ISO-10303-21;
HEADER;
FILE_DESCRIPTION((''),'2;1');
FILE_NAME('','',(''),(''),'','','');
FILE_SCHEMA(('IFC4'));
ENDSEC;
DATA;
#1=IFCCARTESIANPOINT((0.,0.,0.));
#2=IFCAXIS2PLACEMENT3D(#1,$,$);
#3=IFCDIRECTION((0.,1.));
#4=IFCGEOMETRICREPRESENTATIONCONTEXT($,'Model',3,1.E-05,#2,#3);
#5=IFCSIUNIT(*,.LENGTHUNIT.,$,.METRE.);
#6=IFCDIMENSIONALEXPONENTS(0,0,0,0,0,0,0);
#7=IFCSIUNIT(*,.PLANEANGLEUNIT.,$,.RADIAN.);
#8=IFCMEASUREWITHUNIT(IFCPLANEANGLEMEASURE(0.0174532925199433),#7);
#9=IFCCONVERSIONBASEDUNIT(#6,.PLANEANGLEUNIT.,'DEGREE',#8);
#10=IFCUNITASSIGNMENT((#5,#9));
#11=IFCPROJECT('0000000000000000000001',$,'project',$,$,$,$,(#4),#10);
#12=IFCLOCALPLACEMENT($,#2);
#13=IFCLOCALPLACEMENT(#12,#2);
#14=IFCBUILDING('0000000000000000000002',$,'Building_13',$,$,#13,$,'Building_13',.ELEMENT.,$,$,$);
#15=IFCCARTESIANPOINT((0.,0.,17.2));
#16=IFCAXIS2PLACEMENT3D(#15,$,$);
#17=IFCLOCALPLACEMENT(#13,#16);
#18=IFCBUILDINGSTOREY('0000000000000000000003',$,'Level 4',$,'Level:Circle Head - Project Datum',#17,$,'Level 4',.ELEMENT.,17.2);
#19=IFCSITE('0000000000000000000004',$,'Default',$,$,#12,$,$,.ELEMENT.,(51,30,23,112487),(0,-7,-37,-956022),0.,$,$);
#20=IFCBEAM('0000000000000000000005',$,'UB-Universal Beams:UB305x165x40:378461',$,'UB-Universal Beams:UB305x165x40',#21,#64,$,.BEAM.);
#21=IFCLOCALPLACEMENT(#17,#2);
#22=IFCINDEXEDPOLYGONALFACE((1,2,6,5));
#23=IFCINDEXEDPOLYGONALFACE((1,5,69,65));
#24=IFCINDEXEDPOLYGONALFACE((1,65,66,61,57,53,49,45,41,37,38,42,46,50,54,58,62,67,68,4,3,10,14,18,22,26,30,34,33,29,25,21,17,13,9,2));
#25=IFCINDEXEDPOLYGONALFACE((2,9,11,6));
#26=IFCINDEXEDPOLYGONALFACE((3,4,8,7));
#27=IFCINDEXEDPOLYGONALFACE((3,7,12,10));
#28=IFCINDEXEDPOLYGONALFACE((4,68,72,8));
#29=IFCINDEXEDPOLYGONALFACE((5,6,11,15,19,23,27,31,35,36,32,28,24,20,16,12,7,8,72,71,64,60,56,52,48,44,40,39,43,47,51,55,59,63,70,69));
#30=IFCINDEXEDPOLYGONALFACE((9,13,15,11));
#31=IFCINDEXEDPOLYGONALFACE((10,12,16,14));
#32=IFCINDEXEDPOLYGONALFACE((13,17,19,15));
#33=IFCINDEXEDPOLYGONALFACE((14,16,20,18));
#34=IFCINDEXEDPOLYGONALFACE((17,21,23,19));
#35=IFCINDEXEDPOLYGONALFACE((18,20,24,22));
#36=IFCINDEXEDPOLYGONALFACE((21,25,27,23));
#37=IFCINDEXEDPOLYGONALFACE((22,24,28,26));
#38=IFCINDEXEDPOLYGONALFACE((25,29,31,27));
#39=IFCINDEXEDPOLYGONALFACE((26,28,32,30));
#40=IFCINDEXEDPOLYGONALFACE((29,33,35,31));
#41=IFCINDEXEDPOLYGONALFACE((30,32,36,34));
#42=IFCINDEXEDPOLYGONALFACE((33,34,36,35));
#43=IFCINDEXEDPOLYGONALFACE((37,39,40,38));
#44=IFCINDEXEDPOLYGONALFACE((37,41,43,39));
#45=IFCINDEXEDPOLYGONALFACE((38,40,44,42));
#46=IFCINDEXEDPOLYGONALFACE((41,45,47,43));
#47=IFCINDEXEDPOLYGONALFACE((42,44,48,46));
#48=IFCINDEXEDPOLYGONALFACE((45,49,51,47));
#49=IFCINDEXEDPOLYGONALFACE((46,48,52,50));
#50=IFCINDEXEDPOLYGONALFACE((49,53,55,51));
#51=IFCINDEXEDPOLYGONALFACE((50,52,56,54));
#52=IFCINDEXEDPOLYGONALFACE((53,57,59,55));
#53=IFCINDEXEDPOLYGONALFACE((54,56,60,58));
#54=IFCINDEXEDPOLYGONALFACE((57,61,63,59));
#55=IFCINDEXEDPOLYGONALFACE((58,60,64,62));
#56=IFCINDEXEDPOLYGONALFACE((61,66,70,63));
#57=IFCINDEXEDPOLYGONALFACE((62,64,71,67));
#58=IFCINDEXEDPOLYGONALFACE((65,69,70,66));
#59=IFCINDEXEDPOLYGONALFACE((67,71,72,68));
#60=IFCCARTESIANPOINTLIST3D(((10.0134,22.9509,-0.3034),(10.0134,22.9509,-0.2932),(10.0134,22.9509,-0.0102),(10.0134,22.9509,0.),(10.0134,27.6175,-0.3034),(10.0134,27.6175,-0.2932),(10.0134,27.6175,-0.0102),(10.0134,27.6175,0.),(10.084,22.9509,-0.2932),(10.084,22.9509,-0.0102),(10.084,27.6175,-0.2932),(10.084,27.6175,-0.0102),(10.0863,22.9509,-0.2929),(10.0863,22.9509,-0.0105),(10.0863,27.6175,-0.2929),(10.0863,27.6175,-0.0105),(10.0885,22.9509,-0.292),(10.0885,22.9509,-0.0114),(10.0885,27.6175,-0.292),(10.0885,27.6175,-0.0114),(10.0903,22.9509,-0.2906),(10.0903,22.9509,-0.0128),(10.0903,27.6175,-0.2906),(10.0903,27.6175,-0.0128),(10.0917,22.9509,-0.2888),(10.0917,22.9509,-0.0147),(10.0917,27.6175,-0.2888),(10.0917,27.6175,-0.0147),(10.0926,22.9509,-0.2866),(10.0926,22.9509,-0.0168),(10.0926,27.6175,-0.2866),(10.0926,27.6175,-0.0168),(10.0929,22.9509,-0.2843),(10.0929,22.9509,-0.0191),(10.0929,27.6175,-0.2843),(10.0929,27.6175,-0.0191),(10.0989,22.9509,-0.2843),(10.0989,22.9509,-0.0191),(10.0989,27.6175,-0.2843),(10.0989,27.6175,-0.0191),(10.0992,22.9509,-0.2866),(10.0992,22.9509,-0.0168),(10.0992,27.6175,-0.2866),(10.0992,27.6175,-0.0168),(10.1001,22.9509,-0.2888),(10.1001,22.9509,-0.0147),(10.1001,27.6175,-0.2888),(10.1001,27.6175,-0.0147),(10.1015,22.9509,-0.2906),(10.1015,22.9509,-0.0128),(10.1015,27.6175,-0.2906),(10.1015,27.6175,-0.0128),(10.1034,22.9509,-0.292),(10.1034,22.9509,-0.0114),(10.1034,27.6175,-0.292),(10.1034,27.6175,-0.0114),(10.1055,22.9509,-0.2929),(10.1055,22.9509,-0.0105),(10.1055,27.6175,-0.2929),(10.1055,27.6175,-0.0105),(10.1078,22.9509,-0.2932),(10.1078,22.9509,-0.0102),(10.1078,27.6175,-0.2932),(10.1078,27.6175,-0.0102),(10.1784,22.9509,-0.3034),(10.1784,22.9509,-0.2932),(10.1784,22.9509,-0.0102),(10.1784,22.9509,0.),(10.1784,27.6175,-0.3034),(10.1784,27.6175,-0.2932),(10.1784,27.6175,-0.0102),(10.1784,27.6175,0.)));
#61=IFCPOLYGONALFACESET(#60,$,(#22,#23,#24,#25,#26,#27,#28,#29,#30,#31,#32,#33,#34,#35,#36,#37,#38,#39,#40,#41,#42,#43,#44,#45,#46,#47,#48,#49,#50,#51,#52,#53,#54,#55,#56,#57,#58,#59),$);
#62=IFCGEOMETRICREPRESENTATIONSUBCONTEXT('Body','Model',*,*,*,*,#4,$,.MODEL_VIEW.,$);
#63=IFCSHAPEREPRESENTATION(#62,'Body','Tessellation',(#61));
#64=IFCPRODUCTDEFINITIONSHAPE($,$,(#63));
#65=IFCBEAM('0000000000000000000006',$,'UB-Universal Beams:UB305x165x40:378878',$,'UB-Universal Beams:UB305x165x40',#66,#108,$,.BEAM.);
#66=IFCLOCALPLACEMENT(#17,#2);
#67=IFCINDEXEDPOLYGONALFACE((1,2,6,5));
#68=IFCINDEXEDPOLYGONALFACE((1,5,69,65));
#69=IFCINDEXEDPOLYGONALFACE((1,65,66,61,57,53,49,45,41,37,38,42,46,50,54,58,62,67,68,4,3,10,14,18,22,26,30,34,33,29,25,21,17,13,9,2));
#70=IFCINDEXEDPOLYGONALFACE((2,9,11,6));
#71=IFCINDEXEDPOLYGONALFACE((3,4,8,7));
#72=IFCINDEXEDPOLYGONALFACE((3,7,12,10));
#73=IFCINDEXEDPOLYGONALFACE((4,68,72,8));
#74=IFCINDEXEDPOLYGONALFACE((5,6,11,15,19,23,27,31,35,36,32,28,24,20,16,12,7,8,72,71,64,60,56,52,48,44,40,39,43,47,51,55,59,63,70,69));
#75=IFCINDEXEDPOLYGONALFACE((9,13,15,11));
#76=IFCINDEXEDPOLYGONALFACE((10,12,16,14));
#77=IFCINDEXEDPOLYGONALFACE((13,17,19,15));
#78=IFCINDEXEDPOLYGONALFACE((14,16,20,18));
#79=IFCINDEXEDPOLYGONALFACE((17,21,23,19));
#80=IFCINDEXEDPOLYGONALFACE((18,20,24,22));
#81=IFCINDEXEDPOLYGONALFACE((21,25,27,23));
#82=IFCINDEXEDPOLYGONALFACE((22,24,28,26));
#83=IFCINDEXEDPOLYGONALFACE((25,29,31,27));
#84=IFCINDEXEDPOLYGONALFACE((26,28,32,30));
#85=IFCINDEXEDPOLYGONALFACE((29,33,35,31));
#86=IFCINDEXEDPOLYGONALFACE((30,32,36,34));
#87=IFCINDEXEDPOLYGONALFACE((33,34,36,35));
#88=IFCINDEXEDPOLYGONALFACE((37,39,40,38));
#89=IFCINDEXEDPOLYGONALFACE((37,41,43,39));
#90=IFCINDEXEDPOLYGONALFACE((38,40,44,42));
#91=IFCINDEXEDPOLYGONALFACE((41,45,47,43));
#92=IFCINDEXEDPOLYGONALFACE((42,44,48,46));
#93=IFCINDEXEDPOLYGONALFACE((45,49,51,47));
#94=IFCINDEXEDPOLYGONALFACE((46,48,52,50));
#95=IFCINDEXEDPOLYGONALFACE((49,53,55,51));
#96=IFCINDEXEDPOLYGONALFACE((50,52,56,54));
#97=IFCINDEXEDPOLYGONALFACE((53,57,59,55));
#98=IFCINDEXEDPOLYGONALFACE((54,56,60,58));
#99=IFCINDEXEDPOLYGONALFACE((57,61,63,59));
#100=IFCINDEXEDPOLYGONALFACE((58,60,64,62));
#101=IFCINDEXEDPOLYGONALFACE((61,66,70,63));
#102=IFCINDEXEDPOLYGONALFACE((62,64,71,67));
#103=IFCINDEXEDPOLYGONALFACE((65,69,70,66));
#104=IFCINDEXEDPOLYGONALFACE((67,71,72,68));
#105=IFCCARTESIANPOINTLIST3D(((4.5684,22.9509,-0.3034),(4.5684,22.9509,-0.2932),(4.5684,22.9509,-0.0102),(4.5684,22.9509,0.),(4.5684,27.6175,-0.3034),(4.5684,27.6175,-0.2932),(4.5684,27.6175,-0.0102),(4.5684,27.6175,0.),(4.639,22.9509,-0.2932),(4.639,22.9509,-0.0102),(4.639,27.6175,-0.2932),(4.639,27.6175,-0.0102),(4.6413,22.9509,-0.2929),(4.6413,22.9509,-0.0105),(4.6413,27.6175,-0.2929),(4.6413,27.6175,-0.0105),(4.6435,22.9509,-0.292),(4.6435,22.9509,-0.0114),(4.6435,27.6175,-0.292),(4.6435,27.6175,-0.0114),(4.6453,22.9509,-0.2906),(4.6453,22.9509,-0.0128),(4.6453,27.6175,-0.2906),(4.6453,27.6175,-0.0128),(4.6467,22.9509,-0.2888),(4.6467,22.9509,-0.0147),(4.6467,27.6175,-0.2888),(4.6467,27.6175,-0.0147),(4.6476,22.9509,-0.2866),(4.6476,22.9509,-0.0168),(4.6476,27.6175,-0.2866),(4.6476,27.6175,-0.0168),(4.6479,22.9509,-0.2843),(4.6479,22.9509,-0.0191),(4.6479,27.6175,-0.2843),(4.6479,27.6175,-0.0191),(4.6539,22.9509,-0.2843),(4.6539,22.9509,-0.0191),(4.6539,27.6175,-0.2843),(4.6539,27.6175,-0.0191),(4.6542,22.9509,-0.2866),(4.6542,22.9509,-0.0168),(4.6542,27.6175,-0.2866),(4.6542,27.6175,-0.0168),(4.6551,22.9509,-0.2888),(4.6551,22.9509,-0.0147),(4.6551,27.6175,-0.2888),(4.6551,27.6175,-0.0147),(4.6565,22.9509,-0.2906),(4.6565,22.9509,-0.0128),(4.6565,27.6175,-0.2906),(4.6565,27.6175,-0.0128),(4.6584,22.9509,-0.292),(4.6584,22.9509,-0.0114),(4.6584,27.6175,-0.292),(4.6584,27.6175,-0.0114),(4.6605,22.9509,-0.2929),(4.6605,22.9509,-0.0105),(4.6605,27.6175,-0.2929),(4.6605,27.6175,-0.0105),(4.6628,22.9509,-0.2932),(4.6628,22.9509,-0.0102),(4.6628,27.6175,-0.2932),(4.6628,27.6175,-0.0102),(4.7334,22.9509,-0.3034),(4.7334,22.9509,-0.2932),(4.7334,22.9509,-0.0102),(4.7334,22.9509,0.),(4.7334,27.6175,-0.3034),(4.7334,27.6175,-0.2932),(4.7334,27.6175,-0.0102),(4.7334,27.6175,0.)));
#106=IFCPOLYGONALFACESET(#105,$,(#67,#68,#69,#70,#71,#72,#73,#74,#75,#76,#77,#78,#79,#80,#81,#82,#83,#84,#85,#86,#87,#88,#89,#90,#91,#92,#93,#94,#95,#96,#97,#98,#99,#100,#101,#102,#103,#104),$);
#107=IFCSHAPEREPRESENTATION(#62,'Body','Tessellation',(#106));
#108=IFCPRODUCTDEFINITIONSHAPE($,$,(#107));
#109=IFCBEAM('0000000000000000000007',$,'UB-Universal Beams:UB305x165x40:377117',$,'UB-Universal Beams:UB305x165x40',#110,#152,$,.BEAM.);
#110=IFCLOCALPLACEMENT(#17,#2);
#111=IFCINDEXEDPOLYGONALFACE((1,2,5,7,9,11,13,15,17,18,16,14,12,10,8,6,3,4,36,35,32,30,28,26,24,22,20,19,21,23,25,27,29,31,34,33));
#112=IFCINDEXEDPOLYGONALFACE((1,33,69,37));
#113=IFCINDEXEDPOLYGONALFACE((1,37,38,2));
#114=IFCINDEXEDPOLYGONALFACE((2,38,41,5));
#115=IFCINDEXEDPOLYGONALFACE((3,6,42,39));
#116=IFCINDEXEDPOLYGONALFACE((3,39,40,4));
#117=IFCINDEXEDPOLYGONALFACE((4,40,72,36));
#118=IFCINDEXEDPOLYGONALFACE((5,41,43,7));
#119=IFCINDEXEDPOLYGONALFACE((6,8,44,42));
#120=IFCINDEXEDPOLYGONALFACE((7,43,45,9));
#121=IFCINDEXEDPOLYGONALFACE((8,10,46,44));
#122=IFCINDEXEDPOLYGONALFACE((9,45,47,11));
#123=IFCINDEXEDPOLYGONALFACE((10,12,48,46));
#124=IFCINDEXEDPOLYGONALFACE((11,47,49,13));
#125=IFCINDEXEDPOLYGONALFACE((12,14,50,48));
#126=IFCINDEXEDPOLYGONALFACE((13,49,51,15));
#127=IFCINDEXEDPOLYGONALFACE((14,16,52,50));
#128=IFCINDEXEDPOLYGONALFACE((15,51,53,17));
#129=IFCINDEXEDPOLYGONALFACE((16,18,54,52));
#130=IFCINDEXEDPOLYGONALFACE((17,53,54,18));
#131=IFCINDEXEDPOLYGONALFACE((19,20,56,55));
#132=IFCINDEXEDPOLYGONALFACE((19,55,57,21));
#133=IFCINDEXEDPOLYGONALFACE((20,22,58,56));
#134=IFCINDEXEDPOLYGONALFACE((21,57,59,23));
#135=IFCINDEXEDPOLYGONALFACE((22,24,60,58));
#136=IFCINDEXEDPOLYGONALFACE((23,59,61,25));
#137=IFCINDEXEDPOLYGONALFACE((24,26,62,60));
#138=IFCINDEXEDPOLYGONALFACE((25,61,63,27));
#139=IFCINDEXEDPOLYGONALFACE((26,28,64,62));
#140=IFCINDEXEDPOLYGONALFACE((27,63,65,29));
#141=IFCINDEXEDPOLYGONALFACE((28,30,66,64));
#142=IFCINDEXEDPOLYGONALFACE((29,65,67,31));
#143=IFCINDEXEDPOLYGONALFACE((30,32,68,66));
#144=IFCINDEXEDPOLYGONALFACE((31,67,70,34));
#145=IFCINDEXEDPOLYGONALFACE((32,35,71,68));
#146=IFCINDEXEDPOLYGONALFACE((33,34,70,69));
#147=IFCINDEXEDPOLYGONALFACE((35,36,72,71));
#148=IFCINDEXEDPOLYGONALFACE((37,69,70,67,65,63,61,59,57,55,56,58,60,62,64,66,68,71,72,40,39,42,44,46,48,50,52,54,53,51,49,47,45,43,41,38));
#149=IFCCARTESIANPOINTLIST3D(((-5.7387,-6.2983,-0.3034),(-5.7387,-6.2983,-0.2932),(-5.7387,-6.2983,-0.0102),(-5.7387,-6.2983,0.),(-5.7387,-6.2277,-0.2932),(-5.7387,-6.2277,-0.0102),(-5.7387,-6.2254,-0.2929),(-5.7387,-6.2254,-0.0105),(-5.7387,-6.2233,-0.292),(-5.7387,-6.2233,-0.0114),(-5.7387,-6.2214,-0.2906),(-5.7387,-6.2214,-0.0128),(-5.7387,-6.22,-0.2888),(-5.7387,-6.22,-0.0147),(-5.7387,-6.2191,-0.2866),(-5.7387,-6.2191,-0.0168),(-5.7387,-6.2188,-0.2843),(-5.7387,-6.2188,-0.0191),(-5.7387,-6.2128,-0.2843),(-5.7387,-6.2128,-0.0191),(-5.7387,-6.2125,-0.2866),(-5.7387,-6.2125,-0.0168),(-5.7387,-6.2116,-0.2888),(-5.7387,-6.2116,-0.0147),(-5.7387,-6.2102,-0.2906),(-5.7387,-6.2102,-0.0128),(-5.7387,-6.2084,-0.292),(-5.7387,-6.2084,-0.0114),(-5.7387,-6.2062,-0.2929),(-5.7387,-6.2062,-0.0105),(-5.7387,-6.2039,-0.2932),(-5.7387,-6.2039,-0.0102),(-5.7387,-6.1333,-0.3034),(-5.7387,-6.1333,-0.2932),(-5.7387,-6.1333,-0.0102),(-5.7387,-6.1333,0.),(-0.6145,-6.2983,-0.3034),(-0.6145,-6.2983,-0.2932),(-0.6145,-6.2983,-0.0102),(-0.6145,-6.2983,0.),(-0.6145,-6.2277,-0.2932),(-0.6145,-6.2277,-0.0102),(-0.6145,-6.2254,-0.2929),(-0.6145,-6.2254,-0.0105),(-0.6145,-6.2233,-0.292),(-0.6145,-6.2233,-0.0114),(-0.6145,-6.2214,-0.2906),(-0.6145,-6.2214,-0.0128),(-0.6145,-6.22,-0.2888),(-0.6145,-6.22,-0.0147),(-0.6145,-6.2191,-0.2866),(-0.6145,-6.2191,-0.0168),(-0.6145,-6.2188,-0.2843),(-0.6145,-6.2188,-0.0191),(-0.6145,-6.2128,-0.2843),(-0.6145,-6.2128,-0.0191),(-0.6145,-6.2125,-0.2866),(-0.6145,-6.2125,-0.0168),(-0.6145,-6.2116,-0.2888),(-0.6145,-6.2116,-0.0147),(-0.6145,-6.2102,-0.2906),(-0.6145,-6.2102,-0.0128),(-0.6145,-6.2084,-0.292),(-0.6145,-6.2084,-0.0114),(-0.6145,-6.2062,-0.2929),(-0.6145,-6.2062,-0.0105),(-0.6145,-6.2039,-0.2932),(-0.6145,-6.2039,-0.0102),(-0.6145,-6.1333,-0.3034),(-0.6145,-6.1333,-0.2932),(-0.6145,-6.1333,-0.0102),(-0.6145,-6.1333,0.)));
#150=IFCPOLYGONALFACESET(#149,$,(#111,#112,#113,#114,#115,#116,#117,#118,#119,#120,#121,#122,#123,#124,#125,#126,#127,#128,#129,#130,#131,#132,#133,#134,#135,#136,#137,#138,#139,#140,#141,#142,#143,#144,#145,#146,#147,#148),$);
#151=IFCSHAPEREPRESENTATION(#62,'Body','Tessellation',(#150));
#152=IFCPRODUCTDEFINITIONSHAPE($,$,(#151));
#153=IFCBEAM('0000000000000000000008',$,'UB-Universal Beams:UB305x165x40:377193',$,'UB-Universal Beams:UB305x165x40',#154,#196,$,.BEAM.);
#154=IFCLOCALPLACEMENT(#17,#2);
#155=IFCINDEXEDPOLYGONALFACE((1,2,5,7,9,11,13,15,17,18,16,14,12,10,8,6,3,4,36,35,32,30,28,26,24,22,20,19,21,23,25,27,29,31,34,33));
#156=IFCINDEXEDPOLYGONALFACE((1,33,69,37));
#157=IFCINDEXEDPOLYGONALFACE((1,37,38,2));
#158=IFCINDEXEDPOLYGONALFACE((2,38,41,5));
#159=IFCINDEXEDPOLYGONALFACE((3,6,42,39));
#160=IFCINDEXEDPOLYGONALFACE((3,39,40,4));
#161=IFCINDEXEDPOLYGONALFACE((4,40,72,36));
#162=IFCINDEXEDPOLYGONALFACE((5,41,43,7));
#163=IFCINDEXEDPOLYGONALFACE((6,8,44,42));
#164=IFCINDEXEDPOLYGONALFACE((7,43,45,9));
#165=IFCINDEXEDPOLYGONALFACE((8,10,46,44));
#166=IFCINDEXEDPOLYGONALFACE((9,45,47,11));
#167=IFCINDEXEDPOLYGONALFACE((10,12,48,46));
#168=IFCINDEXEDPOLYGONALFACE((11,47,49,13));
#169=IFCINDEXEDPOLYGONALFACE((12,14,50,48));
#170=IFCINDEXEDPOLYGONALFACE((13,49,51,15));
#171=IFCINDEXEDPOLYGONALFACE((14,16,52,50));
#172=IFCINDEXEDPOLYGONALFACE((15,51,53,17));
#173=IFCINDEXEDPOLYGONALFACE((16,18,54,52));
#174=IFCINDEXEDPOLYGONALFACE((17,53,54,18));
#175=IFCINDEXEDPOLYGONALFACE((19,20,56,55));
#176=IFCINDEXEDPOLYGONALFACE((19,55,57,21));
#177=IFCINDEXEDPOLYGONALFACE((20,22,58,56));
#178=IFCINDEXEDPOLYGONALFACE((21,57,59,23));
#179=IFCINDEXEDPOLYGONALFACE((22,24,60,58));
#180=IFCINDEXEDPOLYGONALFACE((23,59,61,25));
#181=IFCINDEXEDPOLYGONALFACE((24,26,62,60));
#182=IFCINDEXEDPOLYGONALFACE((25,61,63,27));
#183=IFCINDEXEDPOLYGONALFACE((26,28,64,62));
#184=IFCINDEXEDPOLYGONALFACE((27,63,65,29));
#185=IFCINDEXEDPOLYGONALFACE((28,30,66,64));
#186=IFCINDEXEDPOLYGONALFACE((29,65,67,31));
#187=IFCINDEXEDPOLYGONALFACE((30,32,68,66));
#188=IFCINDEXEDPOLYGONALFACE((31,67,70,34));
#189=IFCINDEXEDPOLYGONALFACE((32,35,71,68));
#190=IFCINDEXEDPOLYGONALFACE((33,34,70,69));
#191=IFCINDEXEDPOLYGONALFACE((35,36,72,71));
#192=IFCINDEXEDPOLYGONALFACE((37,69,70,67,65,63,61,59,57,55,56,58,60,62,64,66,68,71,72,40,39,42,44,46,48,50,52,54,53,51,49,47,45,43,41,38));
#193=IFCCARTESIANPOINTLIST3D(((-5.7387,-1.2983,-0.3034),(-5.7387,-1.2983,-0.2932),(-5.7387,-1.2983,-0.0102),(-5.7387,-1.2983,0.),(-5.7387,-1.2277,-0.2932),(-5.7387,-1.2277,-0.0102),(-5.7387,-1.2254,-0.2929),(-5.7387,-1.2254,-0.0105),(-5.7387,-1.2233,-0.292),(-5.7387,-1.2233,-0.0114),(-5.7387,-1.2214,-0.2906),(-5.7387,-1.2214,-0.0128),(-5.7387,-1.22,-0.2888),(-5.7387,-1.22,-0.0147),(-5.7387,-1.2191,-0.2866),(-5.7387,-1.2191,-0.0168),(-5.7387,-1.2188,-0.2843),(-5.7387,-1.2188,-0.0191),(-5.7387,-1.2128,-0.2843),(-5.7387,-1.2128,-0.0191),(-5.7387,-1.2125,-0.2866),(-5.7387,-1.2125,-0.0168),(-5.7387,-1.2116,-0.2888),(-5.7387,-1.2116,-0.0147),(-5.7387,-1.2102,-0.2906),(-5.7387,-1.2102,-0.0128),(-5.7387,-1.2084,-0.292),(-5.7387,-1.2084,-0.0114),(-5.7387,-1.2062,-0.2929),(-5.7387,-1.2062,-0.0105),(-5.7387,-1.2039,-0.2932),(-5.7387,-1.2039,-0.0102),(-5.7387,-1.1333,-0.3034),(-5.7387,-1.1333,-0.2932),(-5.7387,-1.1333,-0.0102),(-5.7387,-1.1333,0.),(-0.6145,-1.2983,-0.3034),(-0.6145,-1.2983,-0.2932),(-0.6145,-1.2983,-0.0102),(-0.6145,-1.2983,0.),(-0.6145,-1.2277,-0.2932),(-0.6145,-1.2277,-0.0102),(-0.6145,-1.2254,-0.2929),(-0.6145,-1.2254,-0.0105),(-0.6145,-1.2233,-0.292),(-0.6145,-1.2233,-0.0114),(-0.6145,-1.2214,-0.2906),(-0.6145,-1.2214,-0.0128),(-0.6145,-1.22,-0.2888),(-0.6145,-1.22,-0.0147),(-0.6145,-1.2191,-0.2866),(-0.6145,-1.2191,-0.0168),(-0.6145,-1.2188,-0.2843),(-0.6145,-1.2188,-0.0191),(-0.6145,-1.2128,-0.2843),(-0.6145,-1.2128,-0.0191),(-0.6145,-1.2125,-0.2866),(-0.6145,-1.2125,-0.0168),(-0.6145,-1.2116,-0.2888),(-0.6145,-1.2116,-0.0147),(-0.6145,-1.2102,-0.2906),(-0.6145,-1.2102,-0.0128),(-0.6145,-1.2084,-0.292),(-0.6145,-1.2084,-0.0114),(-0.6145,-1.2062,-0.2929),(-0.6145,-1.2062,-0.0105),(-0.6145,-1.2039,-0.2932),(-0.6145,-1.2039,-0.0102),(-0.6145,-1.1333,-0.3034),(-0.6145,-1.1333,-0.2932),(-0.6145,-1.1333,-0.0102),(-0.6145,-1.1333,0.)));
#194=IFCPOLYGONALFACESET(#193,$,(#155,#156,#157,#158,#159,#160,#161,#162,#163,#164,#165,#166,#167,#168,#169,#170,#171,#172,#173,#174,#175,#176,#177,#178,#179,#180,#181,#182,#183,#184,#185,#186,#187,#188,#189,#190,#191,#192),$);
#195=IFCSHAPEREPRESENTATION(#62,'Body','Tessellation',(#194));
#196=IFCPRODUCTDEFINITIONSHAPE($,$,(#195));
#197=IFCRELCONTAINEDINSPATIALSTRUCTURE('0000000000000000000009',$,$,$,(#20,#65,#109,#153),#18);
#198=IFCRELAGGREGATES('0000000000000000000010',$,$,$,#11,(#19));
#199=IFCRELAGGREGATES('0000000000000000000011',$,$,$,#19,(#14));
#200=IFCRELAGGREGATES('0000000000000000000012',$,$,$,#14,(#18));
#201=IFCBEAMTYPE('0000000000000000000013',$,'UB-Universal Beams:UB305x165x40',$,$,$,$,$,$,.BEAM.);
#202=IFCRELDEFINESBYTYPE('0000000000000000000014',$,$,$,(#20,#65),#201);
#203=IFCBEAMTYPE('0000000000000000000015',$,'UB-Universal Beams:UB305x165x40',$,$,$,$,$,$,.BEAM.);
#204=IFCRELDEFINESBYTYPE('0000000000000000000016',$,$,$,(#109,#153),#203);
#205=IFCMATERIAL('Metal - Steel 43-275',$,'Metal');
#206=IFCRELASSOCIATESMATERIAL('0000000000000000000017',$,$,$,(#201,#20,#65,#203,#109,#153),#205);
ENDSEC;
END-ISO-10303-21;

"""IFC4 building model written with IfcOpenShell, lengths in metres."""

from ifc_helpers import new_model, entity, si_unit, converted_unit, direction, frame, origin, place, context, subcontext, project, spatial, line, arc, indexed_curve, outline, extrude, source, transform, mapped, material, type_object, type_shapes, element, save


model = new_model("IFC4")

# Units and contexts
model_context = context("Model", 3, precision=1e-05, world=origin(), true_north=direction((0.0, 1.0)))
body_context = subcontext(model_context, "Body", "Model", "MODEL_VIEW")
ifc_project = project(units=[si_unit("LENGTHUNIT", "METRE"), converted_unit("PLANEANGLEUNIT", "DEGREE", entity("IfcPlaneAngleMeasure", 0.0174532925199433), si_unit("PLANEANGLEUNIT", "RADIAN"), dimensions=[0, 0, 0, 0, 0, 0, 0])], contexts=[model_context])

# Site, building, storey
site_placement = place(None, origin())
site = spatial("IfcSite", under=ifc_project, at=site_placement, Name="Default", CompositionType="ELEMENT", RefLatitude=(51, 30, 23, 112487), RefLongitude=(0, -7, -37, -956022), RefElevation=0.0)
building_placement = place(site_placement, origin())
building = spatial("IfcBuilding", under=site, at=building_placement, Name="Building_13", LongName="Building_13", CompositionType="ELEMENT")
storey_placement = place(building_placement, frame((0.0, 0.0, 17.2)))
storey = spatial("IfcBuildingStorey", under=building, at=storey_placement, Name="Level 4", ObjectType="Level:Circle Head - Project Datum", LongName="Level 4", CompositionType="ELEMENT", Elevation=17.2)

# Beams
ifc_material_1 = material(Name="Metal - Steel 43-275", Category="Metal")
beam_type_1 = type_object("IfcBeamType", Name="UB-Universal Beams:UB305x165x40", PredefinedType="BEAM", material=ifc_material_1)
shared_shape_1 = source(origin(), body_context, "Body", "SweptSolid", [
    extrude(outline(indexed_curve([(-0.0825, -0.1415), (-0.0825, -0.1517), (0.0825, -0.1517), (0.0825, -0.1415), (0.0119, -0.1415), (0.0056, -0.1389), (0.003, -0.1326), (0.003, 0.1326), (0.0056, 0.1389), (0.0119, 0.1415), (0.0825, 0.1415), (0.0825, 0.1517), (-0.0825, 0.1517), (-0.0825, 0.1415), (-0.0119, 0.1415), (-0.0056, 0.1389), (-0.003, 0.1326), (-0.003, -0.1326), (-0.0056, -0.1389), (-0.0119, -0.1415)], segments=[line(1, 2, 3, 4, 5), arc(5, 6, 7), line(7, 8), arc(8, 9, 10), line(10, 11, 12, 13, 14, 15), arc(15, 16, 17), line(17, 18), arc(18, 19, 20), line(20, 1)], self_intersect=False)), frame((-2.3333, 0.0, 0.0), z_axis=(-1.0, 0.0, 0.0), x_axis=(0.0, -1.0, 0.0)), (0.0, 0.0, -1.0), 4.6666),
])
type_shapes(beam_type_1, [shared_shape_1])
for number, where, z_axis, x_axis, name in (
    (1, (10.0959, 25.2842, -0.1517), (0.0, 0.0, 1.0), (0.0, -1.0, 0.0), "UB-Universal Beams:UB305x165x40:378461"),
    (2, (4.6509, 25.2842, -0.1517), (0.0, 0.0, 1.0), (0.0, -1.0, 0.0), "UB-Universal Beams:UB305x165x40:378878"),
):
    element("IfcBeam", number, at=place(storey_placement, frame(where, z_axis=z_axis, x_axis=x_axis)), inside=storey, type_object=beam_type_1, material=ifc_material_1, Name=name, ObjectType="UB-Universal Beams:UB305x165x40", PredefinedType="BEAM", context=body_context, shape_type="MappedRepresentation", body=[
        mapped(shared_shape_1, transform((0.0, 0.0, 0.0), scale=1.0)),
    ])
beam_type_2 = type_object("IfcBeamType", Name="UB-Universal Beams:UB305x165x40", PredefinedType="BEAM", material=ifc_material_1)
shared_shape_2 = source(origin(), body_context, "Body", "SweptSolid", [
    extrude(outline(indexed_curve([(-0.0825, -0.1415), (-0.0825, -0.1517), (0.0825, -0.1517), (0.0825, -0.1415), (0.0119, -0.1415), (0.0056, -0.1389), (0.003, -0.1326), (0.003, 0.1326), (0.0056, 0.1389), (0.0119, 0.1415), (0.0825, 0.1415), (0.0825, 0.1517), (-0.0825, 0.1517), (-0.0825, 0.1415), (-0.0119, 0.1415), (-0.0056, 0.1389), (-0.003, 0.1326), (-0.003, -0.1326), (-0.0056, -0.1389), (-0.0119, -0.1415)], segments=[line(1, 2, 3, 4, 5), arc(5, 6, 7), line(7, 8), arc(8, 9, 10), line(10, 11, 12, 13, 14, 15), arc(15, 16, 17), line(17, 18), arc(18, 19, 20), line(20, 1)], self_intersect=False)), frame((-2.5621, 0.0, 0.0), z_axis=(-1.0, 0.0, 0.0), x_axis=(0.0, -1.0, 0.0)), (0.0, 0.0, -1.0), 5.1242),
])
type_shapes(beam_type_2, [shared_shape_2])
for number, where, name in (
    (3, (-3.1766, -6.2158, -0.1517), "UB-Universal Beams:UB305x165x40:377117"),
    (4, (-3.1766, -1.2158, -0.1517), "UB-Universal Beams:UB305x165x40:377193"),
):
    element("IfcBeam", number, at=place(storey_placement, frame(where)), inside=storey, type_object=beam_type_2, material=ifc_material_1, Name=name, ObjectType="UB-Universal Beams:UB305x165x40", PredefinedType="BEAM", context=body_context, shape_type="MappedRepresentation", body=[
        mapped(shared_shape_2, transform((0.0, 0.0, 0.0), scale=1.0)),
    ])

save(model, "model.ifc")
